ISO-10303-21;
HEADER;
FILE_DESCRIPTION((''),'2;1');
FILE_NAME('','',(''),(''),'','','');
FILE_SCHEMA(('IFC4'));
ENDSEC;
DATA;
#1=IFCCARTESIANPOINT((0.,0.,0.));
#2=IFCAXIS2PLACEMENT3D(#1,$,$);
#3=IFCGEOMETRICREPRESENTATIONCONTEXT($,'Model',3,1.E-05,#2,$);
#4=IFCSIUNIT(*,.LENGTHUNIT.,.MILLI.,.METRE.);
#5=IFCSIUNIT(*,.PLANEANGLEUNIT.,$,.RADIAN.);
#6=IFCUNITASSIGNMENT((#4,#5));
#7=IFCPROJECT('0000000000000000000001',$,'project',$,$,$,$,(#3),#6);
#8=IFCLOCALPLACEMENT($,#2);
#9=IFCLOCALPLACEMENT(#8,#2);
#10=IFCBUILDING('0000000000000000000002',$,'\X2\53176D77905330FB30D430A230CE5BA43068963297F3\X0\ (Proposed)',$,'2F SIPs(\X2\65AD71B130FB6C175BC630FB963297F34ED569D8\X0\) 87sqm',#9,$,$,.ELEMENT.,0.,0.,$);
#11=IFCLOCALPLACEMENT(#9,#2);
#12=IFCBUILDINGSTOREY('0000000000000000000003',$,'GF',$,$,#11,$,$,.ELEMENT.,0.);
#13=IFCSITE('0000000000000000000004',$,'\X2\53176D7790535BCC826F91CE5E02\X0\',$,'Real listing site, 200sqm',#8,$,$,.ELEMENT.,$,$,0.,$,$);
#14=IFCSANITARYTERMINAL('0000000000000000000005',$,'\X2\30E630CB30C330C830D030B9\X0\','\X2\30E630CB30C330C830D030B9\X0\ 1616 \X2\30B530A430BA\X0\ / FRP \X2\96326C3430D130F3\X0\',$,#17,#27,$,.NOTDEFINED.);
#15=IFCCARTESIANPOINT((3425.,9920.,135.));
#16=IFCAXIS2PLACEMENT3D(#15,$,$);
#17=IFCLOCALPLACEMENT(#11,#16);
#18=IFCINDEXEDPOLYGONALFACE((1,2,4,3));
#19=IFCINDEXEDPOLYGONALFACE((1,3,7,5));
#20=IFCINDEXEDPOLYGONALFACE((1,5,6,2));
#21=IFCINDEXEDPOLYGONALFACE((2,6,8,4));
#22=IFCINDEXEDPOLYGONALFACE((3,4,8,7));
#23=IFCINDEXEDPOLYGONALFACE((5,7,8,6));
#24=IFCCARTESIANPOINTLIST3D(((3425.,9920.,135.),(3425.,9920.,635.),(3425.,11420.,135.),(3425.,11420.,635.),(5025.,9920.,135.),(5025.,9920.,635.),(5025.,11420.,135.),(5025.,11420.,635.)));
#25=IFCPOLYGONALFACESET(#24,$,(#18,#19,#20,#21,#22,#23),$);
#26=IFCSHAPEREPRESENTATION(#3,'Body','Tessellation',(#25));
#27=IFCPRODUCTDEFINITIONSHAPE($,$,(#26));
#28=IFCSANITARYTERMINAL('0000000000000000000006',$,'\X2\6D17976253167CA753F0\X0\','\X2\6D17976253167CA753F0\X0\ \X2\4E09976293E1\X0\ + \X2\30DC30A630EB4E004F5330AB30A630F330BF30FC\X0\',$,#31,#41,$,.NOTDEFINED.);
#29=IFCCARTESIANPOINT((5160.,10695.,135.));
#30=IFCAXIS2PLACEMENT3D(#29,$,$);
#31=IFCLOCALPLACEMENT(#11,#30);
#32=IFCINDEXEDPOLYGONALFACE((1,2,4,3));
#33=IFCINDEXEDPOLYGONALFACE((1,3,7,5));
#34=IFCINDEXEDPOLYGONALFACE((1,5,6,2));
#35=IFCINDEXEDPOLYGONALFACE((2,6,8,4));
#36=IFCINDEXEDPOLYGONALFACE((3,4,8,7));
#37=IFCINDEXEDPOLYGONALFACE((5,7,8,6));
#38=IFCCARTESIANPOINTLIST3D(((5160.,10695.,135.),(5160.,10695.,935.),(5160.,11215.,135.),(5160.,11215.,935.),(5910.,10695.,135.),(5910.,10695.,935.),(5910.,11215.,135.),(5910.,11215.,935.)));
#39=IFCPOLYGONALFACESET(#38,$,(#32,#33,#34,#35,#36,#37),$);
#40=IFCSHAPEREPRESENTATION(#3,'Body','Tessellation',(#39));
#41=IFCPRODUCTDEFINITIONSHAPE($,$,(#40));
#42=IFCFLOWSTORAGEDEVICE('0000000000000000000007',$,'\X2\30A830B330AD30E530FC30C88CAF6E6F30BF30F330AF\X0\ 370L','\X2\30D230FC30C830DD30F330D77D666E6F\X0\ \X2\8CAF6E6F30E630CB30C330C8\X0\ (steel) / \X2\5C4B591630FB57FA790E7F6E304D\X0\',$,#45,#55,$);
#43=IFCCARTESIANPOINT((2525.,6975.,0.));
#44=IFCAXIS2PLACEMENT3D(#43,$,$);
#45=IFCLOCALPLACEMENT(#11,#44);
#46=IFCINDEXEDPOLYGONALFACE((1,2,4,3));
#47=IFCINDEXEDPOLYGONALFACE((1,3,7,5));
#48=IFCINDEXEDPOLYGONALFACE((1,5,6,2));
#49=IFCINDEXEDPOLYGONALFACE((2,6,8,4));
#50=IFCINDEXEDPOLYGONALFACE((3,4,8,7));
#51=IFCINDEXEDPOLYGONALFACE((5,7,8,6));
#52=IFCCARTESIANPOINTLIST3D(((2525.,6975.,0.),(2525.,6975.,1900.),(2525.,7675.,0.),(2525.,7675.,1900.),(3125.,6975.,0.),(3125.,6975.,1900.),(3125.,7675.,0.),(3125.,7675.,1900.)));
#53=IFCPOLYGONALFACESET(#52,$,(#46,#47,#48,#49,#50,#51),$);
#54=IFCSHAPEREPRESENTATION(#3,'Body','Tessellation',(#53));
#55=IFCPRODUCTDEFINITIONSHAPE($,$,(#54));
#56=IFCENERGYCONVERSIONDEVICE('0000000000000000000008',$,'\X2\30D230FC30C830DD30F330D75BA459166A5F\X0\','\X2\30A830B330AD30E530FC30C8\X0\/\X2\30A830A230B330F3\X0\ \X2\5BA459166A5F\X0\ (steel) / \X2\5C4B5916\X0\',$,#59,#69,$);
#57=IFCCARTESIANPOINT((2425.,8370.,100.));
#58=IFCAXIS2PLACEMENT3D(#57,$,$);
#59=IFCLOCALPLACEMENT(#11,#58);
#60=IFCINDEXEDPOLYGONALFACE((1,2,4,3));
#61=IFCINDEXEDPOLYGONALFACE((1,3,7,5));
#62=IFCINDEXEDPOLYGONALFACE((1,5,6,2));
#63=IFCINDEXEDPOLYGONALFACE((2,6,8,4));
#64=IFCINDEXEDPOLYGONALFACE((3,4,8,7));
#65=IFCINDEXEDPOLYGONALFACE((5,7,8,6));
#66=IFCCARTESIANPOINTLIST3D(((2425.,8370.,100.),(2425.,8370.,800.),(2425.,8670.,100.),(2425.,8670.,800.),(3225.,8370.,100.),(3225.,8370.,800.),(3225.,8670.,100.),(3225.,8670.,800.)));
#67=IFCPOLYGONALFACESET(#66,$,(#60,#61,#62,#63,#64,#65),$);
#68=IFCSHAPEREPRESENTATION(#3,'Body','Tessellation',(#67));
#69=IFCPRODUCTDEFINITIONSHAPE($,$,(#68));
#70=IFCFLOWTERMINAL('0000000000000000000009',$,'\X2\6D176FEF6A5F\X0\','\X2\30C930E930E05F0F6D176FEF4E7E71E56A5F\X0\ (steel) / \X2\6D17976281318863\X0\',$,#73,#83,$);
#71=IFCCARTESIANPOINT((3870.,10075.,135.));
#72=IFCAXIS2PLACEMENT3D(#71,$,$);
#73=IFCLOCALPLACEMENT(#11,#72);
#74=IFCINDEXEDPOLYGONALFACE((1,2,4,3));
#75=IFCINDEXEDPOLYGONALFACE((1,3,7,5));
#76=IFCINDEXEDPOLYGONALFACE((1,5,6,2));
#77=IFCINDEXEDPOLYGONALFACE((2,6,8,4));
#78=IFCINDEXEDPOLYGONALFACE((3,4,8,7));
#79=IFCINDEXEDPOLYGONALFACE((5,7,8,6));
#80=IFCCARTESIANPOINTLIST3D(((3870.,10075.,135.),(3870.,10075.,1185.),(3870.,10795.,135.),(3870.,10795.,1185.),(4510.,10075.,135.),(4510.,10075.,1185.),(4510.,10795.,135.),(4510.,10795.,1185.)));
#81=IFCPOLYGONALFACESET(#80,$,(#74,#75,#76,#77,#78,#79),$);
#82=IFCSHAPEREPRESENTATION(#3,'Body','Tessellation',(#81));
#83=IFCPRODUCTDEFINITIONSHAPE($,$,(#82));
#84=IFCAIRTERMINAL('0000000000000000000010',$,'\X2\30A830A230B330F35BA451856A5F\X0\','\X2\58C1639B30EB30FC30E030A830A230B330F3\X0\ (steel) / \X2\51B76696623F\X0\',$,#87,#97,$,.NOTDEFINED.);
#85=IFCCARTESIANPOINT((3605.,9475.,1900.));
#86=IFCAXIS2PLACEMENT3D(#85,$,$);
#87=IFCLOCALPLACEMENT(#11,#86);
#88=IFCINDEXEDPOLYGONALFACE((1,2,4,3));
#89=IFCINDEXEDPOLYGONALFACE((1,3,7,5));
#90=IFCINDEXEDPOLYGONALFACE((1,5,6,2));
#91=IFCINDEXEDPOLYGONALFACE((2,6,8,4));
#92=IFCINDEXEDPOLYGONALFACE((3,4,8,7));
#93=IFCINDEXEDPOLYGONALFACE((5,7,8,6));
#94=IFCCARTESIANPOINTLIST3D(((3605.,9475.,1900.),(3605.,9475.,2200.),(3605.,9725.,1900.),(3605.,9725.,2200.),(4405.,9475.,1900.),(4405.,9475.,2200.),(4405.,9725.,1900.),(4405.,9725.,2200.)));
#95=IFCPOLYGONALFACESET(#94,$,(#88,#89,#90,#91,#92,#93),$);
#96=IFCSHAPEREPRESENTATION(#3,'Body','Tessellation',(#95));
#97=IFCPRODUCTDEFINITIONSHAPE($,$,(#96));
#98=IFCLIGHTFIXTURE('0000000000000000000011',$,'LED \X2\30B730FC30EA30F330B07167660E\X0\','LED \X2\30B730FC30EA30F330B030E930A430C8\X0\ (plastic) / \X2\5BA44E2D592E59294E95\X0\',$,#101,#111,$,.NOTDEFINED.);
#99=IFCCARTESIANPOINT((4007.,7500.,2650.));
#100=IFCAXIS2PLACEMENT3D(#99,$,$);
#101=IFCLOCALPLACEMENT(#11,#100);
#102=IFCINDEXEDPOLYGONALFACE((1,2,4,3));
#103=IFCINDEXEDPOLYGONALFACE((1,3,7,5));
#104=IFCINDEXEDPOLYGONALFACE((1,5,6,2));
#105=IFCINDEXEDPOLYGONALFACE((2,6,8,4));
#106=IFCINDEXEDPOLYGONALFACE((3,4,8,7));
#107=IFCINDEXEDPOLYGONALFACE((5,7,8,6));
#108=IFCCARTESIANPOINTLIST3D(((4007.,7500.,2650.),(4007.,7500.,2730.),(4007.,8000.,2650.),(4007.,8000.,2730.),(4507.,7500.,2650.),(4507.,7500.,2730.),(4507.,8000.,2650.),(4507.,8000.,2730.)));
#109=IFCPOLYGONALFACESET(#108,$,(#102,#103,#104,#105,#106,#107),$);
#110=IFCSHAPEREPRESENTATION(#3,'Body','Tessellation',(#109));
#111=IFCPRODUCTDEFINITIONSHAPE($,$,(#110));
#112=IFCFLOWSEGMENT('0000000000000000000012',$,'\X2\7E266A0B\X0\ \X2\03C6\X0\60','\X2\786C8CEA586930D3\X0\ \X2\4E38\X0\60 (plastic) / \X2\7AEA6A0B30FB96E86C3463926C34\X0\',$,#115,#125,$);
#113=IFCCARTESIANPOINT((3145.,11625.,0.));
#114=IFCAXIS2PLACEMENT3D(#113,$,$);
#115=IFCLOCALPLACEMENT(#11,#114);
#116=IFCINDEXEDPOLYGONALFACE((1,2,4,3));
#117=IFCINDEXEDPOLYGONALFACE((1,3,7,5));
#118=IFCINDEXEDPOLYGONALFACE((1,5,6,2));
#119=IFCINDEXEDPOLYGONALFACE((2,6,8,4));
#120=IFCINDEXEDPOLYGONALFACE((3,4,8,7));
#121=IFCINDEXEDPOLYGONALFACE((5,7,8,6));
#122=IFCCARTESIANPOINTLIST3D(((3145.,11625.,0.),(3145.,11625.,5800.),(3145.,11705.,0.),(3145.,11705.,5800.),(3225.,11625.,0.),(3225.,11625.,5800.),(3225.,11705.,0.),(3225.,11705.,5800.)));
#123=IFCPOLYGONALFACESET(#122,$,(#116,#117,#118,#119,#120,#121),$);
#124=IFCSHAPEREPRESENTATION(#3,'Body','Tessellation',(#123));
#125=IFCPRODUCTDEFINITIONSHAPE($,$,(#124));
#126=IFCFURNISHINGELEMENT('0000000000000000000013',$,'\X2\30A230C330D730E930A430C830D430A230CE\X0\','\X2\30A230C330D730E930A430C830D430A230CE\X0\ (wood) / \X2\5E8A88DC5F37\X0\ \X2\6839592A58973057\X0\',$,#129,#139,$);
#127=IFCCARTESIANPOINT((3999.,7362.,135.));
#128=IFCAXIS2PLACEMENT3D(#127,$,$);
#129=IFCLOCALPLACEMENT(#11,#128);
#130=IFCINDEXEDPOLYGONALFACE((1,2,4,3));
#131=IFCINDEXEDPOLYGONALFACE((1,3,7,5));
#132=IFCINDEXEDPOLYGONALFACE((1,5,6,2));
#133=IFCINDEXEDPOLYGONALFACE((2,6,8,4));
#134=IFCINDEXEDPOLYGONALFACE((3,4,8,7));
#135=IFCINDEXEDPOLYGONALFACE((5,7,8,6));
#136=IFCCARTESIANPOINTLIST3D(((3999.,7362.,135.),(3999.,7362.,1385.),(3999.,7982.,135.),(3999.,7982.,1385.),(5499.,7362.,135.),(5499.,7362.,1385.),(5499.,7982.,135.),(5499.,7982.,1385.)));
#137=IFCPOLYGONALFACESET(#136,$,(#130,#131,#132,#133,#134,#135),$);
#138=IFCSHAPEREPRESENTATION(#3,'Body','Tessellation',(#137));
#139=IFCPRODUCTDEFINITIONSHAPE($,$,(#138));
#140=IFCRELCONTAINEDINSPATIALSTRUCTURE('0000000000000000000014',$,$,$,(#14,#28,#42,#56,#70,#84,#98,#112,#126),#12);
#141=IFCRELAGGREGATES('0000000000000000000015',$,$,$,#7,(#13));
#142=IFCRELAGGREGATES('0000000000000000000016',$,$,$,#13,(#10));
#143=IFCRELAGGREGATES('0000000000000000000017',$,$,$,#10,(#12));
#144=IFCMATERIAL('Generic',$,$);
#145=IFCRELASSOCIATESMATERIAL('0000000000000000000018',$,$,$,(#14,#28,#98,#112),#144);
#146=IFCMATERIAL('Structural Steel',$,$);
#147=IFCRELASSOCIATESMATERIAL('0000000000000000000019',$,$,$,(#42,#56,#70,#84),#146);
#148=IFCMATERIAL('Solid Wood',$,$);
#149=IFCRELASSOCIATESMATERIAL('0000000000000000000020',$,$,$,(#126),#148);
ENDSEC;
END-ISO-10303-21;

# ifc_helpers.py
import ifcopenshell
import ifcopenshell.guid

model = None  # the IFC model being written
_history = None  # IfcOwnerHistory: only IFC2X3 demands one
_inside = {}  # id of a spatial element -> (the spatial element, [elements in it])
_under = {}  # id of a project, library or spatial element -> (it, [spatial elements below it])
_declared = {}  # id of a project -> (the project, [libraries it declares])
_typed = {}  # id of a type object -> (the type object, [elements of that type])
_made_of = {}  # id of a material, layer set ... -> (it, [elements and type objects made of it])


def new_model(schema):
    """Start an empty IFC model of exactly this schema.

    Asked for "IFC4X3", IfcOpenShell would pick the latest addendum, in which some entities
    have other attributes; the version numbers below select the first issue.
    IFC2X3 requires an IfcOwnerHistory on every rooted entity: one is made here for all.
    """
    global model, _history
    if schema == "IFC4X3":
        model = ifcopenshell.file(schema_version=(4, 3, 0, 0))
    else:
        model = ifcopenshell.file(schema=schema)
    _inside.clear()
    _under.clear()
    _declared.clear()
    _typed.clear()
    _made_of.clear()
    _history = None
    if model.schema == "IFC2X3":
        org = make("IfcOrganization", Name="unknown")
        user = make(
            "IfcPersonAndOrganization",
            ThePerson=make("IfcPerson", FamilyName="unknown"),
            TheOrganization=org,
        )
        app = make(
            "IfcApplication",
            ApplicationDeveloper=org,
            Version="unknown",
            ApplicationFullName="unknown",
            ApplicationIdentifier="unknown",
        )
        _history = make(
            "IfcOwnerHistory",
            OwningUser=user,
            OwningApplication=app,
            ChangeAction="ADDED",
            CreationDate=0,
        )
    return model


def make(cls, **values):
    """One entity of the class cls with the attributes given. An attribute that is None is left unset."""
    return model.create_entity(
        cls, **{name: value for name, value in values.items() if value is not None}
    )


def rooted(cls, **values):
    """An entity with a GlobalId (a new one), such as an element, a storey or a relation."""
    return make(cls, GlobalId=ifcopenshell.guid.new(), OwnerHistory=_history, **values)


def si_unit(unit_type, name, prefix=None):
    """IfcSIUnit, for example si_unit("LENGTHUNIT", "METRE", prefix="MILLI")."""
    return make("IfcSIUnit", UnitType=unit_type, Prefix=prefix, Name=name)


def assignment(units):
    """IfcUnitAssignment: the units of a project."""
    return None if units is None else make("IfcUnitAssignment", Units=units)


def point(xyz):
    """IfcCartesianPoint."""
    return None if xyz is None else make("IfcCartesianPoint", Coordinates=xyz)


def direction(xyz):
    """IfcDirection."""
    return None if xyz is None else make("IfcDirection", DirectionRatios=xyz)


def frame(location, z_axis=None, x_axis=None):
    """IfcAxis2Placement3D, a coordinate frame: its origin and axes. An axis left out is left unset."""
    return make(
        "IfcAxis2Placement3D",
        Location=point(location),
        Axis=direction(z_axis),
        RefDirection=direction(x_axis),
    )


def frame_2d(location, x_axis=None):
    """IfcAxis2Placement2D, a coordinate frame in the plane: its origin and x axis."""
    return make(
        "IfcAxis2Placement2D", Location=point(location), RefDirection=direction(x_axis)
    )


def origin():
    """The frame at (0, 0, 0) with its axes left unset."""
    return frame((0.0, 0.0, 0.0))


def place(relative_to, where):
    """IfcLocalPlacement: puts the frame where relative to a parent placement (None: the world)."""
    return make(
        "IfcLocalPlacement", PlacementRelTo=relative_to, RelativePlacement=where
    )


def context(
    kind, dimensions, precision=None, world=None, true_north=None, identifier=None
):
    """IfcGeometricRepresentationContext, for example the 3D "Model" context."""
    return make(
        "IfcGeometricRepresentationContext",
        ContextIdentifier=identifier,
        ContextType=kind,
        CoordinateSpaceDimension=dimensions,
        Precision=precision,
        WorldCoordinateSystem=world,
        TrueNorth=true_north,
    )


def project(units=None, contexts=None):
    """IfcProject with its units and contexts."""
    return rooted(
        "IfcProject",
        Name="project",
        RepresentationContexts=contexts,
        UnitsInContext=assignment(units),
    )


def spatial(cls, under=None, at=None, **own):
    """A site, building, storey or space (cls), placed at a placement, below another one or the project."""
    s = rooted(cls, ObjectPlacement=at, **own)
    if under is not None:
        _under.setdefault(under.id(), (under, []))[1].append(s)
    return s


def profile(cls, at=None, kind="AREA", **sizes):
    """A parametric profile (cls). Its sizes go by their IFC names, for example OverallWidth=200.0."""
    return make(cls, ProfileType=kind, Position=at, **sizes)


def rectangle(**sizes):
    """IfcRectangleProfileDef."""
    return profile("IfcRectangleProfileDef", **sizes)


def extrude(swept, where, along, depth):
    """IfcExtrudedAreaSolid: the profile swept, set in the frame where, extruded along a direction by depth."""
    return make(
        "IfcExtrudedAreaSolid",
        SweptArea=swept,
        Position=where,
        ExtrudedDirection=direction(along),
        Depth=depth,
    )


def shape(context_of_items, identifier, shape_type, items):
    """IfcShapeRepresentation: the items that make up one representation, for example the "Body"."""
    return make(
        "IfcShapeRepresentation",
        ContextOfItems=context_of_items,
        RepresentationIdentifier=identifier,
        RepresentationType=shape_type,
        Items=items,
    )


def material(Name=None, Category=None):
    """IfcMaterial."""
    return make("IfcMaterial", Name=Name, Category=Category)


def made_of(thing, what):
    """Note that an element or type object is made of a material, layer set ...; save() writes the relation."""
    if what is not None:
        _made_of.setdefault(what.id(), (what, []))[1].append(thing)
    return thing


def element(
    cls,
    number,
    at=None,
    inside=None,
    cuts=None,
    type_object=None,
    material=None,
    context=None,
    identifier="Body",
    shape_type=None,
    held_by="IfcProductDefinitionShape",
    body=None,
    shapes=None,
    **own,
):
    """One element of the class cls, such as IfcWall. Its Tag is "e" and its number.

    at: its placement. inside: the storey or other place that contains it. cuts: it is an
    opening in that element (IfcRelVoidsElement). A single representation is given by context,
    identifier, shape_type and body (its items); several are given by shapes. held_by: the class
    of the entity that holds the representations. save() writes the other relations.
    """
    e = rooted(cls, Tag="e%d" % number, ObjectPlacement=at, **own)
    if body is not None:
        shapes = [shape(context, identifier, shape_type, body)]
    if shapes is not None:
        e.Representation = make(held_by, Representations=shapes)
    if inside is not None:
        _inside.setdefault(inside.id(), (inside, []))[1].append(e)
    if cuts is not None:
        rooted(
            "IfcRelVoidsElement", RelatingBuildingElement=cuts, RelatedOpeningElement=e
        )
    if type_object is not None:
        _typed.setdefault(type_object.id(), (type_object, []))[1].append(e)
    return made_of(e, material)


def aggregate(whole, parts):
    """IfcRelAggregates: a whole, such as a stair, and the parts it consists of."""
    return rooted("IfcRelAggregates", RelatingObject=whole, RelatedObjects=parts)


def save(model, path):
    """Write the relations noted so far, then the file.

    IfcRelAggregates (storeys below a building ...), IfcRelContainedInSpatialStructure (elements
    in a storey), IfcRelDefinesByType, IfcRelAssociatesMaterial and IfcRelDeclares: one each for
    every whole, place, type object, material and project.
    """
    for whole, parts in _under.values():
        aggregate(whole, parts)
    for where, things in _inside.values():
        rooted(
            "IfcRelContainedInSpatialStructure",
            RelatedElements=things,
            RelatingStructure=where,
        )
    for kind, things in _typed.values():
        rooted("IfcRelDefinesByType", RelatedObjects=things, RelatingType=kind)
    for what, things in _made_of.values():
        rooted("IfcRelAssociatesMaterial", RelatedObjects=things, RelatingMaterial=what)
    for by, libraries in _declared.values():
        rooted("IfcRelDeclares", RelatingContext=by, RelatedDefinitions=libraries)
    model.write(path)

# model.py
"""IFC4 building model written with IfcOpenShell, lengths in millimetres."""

from ifc_helpers import new_model, si_unit, frame, frame_2d, origin, place, context, project, spatial, rectangle, extrude, material, element, save


model = new_model("IFC4")

# Units and contexts
model_context = context("Model", 3, precision=1e-05, world=origin())
ifc_project = project(units=[si_unit("LENGTHUNIT", "METRE", prefix="MILLI"), si_unit("PLANEANGLEUNIT", "RADIAN")], contexts=[model_context])

# Site, building, storey
site_placement = place(None, origin())
site = spatial("IfcSite", under=ifc_project, at=site_placement, Name="北海道富良野市", ObjectType="Real listing site, 200sqm", CompositionType="ELEMENT", RefElevation=0.0)
building_placement = place(site_placement, origin())
building = spatial("IfcBuilding", under=site, at=building_placement, Name="北海道・ピアノ室と防音 (Proposed)", ObjectType="2F SIPs(断熱・気密・防音仕様) 87sqm", CompositionType="ELEMENT", ElevationOfRefHeight=0.0, ElevationOfTerrain=0.0)
storey_placement = place(building_placement, origin())
storey = spatial("IfcBuildingStorey", under=building, at=storey_placement, Name="GF", CompositionType="ELEMENT", Elevation=0.0)

# Shared definitions
ifc_material_1 = material(Name="Solid Wood")

# Shared definitions
ifc_material_2 = material(Name="Generic")

# Sanitary terminals
sanitary_terminal_1_placement = place(storey_placement, frame((3425.0, 9920.0, 135.0)))
element("IfcSanitaryTerminal", 1, at=sanitary_terminal_1_placement, inside=storey, material=ifc_material_2, Name="ユニットバス", Description="ユニットバス 1616 サイズ / FRP 防水パン", PredefinedType="NOTDEFINED", context=model_context, shape_type="SweptSolid", body=[
    extrude(rectangle(XDim=1600.0, YDim=1500.0, at=frame_2d((800.0, 750.0))), frame((3425.0, 9920.0, 135.0)), (0.0, 0.0, 1.0), 500.0),
])
sanitary_terminal_2_placement = place(storey_placement, frame((5160.0, 10695.0, 135.0)))
element("IfcSanitaryTerminal", 2, at=sanitary_terminal_2_placement, inside=storey, material=ifc_material_2, Name="洗面化粧台", Description="洗面化粧台 三面鏡 + ボウル一体カウンター", PredefinedType="NOTDEFINED", context=model_context, shape_type="SweptSolid", body=[
    extrude(rectangle(XDim=750.0, YDim=520.0, at=frame_2d((375.0, 260.0))), frame((5160.0, 10695.0, 135.0)), (0.0, 0.0, 1.0), 800.0),
])

# Flow storage device
ifc_material_3 = material(Name="Structural Steel")
flow_storage_device_placement = place(storey_placement, frame((2525.0, 6975.0, 0.0)))
element("IfcFlowStorageDevice", 3, at=flow_storage_device_placement, inside=storey, material=ifc_material_3, Name="エコキュート貯湯タンク 370L", Description="ヒートポンプ給湯 貯湯ユニット (steel) / 屋外・基礎置き", context=model_context, shape_type="SweptSolid", body=[
    extrude(rectangle(XDim=600.0, YDim=700.0, at=frame_2d((300.0, 350.0))), frame((2525.0, 6975.0, 0.0)), (0.0, 0.0, 1.0), 1900.0),
])

# Energy conversion device
energy_conversion_device_placement = place(storey_placement, frame((2425.0, 8370.0, 100.0)))
element("IfcEnergyConversionDevice", 4, at=energy_conversion_device_placement, inside=storey, material=ifc_material_3, Name="ヒートポンプ室外機", Description="エコキュート/エアコン 室外機 (steel) / 屋外", context=model_context, shape_type="SweptSolid", body=[
    extrude(rectangle(XDim=800.0, YDim=300.0, at=frame_2d((400.0, 150.0))), frame((2425.0, 8370.0, 100.0)), (0.0, 0.0, 1.0), 700.0),
])

# Flow terminal
flow_terminal_placement = place(storey_placement, frame((3870.0, 10075.0, 135.0)))
element("IfcFlowTerminal", 5, at=flow_terminal_placement, inside=storey, material=ifc_material_3, Name="洗濯機", Description="ドラム式洗濯乾燥機 (steel) / 洗面脱衣", context=model_context, shape_type="SweptSolid", body=[
    extrude(rectangle(XDim=640.0, YDim=720.0, at=frame_2d((320.0, 360.0))), frame((3870.0, 10075.0, 135.0)), (0.0, 0.0, 1.0), 1050.0),
])

# Air terminal
air_terminal_placement = place(storey_placement, frame((3605.0, 9475.0, 1900.0)))
element("IfcAirTerminal", 6, at=air_terminal_placement, inside=storey, material=ifc_material_3, Name="エアコン室内機", Description="壁掛ルームエアコン (steel) / 冷暖房", PredefinedType="NOTDEFINED", context=model_context, shape_type="SweptSolid", body=[
    extrude(rectangle(XDim=800.0, YDim=250.0, at=frame_2d((400.0, 125.0))), frame((3605.0, 9475.0, 1900.0)), (0.0, 0.0, 1.0), 300.0),
])

# Light fixture
light_fixture_placement = place(storey_placement, frame((4007.0, 7500.0, 2650.0)))
element("IfcLightFixture", 7, at=light_fixture_placement, inside=storey, material=ifc_material_2, Name="LED シーリング照明", Description="LED シーリングライト (plastic) / 室中央天井", PredefinedType="NOTDEFINED", context=model_context, shape_type="SweptSolid", body=[
    extrude(rectangle(XDim=500.0, YDim=500.0, at=frame_2d((250.0, 250.0))), frame((4007.0, 7500.0, 2650.0)), (0.0, 0.0, 1.0), 80.0),
])

# Flow segment
flow_segment_placement = place(storey_placement, frame((3145.0, 11625.0, 0.0)))
element("IfcFlowSegment", 8, at=flow_segment_placement, inside=storey, material=ifc_material_2, Name="縦樋 φ60", Description="硬質塩ビ 丸60 (plastic) / 竪樋・雨水排水", context=model_context, shape_type="SweptSolid", body=[
    extrude(rectangle(XDim=80.0, YDim=80.0, at=frame_2d((40.0, 40.0))), frame((3145.0, 11625.0, 0.0)), (0.0, 0.0, 1.0), 5800.0),
])

# Furnishing element
furnishing_placement = place(storey_placement, frame((3999.0, 7362.0, 135.0)))
element("IfcFurnishingElement", 9, at=furnishing_placement, inside=storey, material=ifc_material_1, Name="アップライトピアノ", Description="アップライトピアノ (wood) / 床補強 根太増し", context=model_context, shape_type="SweptSolid", body=[
    extrude(rectangle(XDim=1500.0, YDim=620.0, at=frame_2d((750.0, 310.0))), frame((3999.0, 7362.0, 135.0)), (0.0, 0.0, 1.0), 1250.0),
])

save(model, "model.ifc")
